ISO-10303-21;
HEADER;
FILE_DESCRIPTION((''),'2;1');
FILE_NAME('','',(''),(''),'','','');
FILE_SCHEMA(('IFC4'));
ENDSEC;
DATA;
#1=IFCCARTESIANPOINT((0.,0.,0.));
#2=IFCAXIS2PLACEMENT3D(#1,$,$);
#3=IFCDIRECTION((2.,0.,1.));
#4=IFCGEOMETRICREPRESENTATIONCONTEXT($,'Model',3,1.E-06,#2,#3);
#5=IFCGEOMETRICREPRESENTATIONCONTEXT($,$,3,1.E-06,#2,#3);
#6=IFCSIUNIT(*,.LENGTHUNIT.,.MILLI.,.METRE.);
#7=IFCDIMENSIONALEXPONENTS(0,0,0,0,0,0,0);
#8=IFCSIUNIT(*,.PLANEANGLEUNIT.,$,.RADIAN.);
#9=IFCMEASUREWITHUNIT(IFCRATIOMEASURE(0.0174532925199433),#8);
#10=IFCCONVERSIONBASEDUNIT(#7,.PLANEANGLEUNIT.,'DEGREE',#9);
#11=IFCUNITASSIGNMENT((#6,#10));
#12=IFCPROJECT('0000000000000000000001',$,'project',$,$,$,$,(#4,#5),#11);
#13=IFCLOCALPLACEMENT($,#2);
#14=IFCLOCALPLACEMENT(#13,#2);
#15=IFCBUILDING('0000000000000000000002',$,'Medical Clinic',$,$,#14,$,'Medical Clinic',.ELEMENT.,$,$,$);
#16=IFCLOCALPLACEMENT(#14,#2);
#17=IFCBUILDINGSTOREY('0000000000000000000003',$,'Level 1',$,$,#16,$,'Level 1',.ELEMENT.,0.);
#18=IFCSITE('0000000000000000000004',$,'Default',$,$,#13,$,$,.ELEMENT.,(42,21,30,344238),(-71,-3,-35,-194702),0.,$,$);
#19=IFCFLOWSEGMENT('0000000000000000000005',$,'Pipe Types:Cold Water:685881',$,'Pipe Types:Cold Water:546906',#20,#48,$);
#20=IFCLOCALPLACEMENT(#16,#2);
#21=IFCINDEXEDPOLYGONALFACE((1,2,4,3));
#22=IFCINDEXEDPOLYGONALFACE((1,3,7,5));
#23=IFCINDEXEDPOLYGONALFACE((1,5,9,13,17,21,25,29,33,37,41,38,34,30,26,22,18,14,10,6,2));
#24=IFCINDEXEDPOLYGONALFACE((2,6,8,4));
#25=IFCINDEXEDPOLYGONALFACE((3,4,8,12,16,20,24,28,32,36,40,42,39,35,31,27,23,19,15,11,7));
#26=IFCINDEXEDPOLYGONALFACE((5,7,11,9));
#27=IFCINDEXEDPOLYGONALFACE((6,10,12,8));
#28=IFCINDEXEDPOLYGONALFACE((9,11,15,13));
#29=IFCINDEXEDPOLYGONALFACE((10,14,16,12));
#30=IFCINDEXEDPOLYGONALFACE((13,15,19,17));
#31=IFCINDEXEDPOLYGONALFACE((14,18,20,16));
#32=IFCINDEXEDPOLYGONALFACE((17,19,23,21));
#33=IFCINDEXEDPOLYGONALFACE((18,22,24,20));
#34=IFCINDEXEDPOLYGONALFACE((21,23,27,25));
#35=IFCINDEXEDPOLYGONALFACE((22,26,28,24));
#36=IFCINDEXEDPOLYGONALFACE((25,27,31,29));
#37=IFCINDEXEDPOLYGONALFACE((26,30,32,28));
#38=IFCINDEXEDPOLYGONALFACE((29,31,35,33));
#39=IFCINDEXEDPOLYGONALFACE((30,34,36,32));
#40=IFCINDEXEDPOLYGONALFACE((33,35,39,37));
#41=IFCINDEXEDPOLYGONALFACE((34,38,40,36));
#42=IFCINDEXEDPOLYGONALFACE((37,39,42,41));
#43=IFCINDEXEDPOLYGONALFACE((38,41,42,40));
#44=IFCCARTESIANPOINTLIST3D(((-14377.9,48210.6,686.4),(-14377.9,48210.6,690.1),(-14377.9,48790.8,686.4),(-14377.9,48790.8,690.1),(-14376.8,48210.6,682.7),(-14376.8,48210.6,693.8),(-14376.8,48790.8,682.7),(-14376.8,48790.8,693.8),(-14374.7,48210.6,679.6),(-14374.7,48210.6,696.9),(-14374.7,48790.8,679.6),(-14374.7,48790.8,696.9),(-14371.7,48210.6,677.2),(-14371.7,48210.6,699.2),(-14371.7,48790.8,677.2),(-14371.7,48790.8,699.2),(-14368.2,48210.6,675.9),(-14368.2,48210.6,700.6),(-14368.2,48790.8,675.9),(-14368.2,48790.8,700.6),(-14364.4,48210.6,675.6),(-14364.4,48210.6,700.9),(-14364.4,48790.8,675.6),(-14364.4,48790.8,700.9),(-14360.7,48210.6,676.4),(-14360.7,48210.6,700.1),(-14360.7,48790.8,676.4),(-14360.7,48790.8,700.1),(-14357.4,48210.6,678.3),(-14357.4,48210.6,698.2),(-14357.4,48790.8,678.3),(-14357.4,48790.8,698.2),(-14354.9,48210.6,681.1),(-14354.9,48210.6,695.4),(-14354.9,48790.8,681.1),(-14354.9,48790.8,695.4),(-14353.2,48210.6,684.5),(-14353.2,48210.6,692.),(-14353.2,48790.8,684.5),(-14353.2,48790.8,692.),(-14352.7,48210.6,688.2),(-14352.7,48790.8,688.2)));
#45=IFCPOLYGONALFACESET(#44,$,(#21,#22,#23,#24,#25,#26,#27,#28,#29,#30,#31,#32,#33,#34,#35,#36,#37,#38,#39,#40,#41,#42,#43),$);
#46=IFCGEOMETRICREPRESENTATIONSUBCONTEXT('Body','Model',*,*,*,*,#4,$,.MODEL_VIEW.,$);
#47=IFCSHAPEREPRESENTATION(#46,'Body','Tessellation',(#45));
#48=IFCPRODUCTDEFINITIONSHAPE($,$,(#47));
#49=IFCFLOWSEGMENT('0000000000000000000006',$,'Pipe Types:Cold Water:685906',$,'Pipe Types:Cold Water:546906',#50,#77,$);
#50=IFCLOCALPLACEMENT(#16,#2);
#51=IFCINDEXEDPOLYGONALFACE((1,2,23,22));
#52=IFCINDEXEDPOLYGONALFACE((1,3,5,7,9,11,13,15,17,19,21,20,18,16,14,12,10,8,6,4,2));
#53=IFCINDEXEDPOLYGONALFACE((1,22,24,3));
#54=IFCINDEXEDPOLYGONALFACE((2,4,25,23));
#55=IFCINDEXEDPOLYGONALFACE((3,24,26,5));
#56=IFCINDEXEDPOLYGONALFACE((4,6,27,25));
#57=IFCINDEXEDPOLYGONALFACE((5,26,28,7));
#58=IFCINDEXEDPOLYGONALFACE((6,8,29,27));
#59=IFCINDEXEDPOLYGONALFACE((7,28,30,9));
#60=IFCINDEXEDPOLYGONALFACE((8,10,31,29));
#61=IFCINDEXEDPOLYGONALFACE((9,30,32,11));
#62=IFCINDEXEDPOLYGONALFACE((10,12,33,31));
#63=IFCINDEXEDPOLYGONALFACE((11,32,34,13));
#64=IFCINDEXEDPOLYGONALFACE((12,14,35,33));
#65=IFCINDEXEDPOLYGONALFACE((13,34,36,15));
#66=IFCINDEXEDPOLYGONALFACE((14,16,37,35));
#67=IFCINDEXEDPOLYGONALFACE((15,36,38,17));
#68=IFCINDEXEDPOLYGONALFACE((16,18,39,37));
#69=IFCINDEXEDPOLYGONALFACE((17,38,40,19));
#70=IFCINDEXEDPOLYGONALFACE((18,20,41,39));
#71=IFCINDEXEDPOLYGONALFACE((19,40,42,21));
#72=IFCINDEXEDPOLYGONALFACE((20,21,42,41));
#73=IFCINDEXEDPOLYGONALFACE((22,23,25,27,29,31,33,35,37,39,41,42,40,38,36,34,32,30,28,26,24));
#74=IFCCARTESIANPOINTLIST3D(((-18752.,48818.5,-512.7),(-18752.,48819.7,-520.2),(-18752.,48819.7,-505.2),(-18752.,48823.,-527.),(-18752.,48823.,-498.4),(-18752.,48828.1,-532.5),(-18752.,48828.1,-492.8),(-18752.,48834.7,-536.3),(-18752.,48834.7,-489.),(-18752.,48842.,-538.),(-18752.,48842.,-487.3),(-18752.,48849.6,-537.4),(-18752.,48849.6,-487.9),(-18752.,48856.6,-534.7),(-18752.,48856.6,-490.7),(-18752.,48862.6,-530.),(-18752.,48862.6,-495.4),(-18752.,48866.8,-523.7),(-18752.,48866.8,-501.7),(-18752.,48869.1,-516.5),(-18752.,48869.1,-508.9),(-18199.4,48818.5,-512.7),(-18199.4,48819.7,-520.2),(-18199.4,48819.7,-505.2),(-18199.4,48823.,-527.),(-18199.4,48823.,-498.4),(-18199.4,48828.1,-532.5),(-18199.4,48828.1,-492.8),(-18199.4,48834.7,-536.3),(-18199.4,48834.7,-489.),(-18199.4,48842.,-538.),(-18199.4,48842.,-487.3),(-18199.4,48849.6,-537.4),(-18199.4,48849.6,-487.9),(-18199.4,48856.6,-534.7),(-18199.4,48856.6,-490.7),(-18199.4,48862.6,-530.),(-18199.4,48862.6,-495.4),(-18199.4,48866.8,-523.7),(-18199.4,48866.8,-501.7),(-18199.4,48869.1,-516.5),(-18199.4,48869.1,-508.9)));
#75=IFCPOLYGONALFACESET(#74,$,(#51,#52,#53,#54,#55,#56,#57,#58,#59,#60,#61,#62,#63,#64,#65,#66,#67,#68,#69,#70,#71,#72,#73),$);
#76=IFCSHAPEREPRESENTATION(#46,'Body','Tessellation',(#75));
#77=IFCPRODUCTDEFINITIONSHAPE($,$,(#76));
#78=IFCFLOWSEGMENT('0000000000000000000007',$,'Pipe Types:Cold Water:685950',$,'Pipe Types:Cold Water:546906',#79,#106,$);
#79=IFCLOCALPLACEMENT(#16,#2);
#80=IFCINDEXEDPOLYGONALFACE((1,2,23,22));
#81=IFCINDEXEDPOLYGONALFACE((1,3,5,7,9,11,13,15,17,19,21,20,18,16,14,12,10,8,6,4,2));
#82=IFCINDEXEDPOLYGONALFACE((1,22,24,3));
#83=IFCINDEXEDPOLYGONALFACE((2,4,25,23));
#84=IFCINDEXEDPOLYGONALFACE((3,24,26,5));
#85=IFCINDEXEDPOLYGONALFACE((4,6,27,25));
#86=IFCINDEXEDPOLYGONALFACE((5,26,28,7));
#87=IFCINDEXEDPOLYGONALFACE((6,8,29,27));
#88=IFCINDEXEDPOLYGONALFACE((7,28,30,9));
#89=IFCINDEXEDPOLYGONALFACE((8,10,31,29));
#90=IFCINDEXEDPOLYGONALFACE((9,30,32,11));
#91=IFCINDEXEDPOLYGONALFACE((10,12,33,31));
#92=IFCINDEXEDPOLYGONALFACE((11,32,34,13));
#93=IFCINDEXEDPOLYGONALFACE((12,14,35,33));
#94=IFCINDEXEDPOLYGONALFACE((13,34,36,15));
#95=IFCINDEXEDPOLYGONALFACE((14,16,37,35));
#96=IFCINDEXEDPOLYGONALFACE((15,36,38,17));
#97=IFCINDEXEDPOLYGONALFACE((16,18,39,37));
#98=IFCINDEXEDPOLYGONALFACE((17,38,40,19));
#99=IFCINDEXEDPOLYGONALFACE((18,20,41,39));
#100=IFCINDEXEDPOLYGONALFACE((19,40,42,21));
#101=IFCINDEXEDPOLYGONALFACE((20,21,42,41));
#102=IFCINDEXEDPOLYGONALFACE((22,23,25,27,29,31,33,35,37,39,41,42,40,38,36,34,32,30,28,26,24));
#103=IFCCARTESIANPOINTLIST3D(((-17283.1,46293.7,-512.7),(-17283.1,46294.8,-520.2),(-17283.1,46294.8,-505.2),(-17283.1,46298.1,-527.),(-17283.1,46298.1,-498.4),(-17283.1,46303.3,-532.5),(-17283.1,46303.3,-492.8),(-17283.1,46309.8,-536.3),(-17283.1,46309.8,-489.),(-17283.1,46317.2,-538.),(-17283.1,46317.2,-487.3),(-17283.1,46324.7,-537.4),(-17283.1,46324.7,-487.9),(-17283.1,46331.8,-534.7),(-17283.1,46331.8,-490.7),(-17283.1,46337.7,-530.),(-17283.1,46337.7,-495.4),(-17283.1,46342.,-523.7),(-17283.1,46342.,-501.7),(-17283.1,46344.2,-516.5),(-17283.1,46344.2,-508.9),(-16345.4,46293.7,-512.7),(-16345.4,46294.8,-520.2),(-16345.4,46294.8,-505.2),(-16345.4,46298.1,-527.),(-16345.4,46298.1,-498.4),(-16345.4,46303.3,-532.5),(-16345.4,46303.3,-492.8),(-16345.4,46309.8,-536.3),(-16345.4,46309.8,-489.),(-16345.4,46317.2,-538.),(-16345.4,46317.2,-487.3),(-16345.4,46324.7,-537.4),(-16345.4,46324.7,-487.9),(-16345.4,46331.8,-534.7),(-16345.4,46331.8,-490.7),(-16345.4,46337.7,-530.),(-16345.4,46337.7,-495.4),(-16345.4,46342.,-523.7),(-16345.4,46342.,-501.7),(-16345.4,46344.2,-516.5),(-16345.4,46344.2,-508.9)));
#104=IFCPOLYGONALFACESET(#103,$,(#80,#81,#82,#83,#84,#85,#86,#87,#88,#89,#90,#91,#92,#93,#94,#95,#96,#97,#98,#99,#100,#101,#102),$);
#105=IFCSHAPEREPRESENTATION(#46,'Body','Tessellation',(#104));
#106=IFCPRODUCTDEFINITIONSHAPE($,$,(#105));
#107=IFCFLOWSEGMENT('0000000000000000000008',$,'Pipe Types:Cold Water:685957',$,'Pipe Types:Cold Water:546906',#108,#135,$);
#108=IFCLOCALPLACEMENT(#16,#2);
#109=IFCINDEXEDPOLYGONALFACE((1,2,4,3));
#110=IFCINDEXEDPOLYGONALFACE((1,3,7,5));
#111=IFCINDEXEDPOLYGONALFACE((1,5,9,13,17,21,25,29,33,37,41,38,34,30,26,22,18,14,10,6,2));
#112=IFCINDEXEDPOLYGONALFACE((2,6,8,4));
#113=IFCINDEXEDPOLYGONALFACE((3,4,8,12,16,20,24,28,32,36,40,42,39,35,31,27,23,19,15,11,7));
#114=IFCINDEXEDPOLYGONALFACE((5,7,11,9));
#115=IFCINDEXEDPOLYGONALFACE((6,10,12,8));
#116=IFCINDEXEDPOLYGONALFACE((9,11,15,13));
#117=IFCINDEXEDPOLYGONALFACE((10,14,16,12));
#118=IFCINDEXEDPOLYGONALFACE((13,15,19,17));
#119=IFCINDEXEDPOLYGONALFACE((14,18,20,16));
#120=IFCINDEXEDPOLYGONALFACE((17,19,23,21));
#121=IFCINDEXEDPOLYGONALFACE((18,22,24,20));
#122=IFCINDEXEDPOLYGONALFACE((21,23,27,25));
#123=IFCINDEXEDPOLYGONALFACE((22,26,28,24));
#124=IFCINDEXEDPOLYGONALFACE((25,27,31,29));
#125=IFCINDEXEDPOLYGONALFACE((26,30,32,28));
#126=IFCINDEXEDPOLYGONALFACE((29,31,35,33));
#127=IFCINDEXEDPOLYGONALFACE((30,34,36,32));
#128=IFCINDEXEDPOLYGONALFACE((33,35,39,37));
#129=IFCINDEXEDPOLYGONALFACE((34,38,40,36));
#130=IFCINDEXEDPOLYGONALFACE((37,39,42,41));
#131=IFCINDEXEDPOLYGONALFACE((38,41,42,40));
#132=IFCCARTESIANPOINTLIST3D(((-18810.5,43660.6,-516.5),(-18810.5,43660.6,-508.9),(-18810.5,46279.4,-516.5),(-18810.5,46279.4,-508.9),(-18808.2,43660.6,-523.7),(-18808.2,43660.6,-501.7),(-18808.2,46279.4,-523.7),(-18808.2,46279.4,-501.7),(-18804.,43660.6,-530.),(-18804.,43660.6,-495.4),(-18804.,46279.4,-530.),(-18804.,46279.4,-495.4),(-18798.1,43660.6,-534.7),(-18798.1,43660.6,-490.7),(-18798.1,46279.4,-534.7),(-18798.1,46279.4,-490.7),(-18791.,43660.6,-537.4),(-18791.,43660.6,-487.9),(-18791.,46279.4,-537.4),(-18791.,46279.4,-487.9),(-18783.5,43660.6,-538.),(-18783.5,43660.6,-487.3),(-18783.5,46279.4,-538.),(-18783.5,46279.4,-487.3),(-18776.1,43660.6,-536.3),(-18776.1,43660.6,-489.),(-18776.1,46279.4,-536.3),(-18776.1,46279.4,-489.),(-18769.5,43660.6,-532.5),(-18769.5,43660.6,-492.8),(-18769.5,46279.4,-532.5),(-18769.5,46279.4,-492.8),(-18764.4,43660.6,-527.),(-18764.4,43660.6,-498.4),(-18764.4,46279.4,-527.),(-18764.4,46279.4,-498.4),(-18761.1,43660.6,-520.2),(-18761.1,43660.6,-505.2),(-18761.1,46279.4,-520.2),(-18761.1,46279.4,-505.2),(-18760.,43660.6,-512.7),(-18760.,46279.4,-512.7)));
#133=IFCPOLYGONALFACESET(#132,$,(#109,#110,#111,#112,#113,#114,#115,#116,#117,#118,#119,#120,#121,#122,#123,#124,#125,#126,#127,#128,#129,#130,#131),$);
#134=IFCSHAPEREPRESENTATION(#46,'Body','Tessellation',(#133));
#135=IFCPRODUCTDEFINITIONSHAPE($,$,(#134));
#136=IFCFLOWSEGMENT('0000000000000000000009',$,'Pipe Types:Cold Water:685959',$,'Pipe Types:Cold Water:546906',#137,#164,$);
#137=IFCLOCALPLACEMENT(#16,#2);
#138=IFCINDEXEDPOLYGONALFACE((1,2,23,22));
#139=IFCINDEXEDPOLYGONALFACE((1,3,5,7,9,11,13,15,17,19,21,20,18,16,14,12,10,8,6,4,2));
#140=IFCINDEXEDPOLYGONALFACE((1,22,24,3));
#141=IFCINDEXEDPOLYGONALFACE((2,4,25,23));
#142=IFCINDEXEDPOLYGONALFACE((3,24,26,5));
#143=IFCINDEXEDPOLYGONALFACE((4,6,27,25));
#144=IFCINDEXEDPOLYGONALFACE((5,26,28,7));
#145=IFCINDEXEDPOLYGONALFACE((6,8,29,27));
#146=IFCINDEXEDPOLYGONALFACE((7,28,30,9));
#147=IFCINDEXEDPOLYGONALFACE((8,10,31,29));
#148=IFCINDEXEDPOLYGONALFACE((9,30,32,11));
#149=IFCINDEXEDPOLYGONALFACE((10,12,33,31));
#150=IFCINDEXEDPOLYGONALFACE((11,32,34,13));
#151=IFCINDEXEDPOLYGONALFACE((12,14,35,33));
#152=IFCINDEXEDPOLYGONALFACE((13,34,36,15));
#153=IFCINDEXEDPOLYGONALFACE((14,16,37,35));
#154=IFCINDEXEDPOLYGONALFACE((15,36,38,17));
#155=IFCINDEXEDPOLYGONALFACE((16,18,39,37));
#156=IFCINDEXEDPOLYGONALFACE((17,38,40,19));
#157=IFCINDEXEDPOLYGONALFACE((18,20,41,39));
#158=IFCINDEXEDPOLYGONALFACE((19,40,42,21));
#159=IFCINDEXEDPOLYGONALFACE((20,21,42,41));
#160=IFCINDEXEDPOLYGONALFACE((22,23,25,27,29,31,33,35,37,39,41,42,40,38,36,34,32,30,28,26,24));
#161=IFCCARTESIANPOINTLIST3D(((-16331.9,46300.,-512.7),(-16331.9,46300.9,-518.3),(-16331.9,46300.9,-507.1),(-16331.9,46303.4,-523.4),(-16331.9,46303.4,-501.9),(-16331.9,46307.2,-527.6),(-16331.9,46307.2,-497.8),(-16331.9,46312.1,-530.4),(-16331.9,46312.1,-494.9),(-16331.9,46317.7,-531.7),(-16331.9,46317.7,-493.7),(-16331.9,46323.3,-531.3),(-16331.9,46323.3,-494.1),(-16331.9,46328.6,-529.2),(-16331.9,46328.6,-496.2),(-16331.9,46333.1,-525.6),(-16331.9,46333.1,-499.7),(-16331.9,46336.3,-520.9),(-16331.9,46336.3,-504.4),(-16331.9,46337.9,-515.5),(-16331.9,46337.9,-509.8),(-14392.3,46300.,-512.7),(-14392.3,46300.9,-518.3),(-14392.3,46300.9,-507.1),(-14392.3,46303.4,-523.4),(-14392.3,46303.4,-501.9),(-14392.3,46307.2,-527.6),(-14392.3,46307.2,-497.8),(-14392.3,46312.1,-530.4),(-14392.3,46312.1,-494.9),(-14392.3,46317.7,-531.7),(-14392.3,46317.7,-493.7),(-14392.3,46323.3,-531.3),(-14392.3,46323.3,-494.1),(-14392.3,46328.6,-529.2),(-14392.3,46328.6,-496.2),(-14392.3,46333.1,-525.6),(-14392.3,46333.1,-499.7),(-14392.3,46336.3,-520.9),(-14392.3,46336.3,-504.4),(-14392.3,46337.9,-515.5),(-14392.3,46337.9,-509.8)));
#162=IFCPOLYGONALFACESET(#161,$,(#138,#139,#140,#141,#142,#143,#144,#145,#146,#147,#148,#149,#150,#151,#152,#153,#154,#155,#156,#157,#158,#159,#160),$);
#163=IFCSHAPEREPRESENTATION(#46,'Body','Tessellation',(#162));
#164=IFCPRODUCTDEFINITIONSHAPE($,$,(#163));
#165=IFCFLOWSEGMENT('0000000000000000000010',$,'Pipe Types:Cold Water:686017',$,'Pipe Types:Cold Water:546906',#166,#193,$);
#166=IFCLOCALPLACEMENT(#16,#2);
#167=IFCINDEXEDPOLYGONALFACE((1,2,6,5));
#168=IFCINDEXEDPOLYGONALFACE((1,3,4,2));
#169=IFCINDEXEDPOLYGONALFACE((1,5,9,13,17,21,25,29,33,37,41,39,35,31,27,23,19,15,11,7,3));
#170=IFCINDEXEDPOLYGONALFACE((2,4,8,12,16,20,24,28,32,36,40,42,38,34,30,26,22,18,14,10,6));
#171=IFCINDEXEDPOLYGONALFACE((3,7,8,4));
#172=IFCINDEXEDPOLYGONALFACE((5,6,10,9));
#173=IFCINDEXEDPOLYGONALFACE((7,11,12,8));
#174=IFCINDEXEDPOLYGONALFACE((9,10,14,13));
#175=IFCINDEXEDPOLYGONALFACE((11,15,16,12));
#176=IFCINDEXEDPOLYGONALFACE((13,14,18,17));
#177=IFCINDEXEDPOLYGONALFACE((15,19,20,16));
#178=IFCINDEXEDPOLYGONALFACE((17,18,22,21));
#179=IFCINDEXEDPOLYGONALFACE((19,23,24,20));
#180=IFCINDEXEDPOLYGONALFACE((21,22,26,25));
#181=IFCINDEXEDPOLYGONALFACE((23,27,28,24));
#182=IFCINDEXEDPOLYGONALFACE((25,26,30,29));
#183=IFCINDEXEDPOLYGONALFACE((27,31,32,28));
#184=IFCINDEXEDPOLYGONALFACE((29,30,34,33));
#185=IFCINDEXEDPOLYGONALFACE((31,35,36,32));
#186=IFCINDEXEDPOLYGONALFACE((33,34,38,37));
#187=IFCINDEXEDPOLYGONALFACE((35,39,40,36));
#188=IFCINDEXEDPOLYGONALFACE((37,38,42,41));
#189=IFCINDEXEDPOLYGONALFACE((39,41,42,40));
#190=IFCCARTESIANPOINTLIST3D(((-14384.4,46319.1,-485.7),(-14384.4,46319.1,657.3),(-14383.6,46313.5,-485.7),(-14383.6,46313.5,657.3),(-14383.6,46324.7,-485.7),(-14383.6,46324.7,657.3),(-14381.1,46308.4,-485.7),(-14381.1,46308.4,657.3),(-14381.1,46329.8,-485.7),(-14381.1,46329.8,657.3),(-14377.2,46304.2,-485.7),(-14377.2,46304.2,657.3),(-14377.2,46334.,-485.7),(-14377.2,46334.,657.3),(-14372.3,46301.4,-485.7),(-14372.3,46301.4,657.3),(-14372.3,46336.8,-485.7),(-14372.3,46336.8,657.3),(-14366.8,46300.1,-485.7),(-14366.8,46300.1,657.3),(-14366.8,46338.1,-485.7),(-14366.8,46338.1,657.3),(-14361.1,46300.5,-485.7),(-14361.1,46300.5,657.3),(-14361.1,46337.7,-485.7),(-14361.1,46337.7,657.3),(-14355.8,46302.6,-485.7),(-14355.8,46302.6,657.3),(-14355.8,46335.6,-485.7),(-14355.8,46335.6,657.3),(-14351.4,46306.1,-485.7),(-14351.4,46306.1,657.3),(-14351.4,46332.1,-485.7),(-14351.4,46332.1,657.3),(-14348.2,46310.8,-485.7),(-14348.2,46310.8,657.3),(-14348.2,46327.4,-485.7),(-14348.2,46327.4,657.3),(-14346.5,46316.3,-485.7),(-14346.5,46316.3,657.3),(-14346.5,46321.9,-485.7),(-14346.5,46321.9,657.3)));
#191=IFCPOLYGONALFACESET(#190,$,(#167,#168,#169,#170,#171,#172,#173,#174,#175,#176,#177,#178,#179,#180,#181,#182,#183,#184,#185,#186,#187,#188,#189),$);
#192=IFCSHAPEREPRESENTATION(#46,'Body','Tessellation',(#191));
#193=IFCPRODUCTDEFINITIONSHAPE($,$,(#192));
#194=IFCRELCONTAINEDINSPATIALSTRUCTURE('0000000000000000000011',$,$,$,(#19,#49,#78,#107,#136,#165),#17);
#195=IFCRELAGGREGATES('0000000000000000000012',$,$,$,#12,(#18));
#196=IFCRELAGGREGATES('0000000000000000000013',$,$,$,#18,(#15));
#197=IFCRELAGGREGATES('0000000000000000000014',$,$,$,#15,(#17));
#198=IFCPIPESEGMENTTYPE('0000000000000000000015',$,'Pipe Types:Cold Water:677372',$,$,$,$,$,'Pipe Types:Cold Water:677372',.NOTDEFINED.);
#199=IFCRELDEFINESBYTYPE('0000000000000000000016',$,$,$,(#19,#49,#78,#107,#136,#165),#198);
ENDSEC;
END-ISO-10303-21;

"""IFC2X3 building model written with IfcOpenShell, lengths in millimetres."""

from ifc_helpers import new_model, entity, si_unit, converted_unit, direction, frame, frame_2d, origin, origin_2d_with_axis, place, context, subcontext, project, spatial, circle, extrude, type_object, element, save


model = new_model("IFC2X3")

# Units and contexts
model_context = context("Model", 3, precision=1e-06, world=origin(), true_north=direction((2.0, 0.0, 1.0)))
context_of_model = context(None, 3, precision=1e-06, world=origin(), true_north=direction((2.0, 0.0, 1.0)))
body_context = subcontext(model_context, "Body", "Model", "MODEL_VIEW")
ifc_project = project(units=[si_unit("LENGTHUNIT", "METRE", prefix="MILLI"), converted_unit("PLANEANGLEUNIT", "DEGREE", entity("IfcRatioMeasure", 0.0174532925199433), si_unit("PLANEANGLEUNIT", "RADIAN"), dimensions=[0, 0, 0, 0, 0, 0, 0])], contexts=[model_context, context_of_model])

# Site, building, storey
site_placement = place(None, origin())
site = spatial("IfcSite", under=ifc_project, at=site_placement, Name="Default", CompositionType="ELEMENT", RefLatitude=(42, 21, 30, 344238), RefLongitude=(-71, -3, -35, -194702), RefElevation=0.0)
building_placement = place(site_placement, origin())
building = spatial("IfcBuilding", under=site, at=building_placement, Name="Medical Clinic", LongName="Medical Clinic", CompositionType="ELEMENT")
storey_placement = place(building_placement, origin())
storey = spatial("IfcBuildingStorey", under=building, at=storey_placement, Name="Level 1", LongName="Level 1", CompositionType="ELEMENT", Elevation=0.0)

# Flow segments
pipe_segment_type = type_object("IfcPipeSegmentType", Name="Pipe Types:Cold Water:677372", ElementType="Pipe Types:Cold Water:677372", PredefinedType="NOTDEFINED")
flow_segment_1_placement = place(storey_placement, origin())
element("IfcFlowSegment", 1, at=flow_segment_1_placement, inside=storey, type_object=pipe_segment_type, Name="Pipe Types:Cold Water:685881", ObjectType="Pipe Types:Cold Water:546906", context=body_context, shape_type="SweptSolid", body=[
    extrude(circle(Radius=12.7, at=origin_2d_with_axis()), frame((-14365.4, 48210.6, 688.2), z_axis=(0.0, 1.0, 0.0), x_axis=(1.0, 0.0, 0.0)), (0.0, 0.0, 1.0), 580.1),
])
flow_segment_2_placement = place(storey_placement, origin())
element("IfcFlowSegment", 2, at=flow_segment_2_placement, inside=storey, type_object=pipe_segment_type, Name="Pipe Types:Cold Water:685906", ObjectType="Pipe Types:Cold Water:546906", context=body_context, shape_type="SweptSolid", body=[
    extrude(circle(Radius=25.4, at=frame_2d((0.0, 0.0), x_axis=(1.0, 0.0))), frame((-18752.0, 48843.9, -512.7), z_axis=(1.0, 0.0, 0.0), x_axis=(0.0, -1.0, 0.0)), (0.0, 0.0, 1.0), 552.6),
])
flow_segment_3_placement = place(storey_placement, origin())
element("IfcFlowSegment", 3, at=flow_segment_3_placement, inside=storey, type_object=pipe_segment_type, Name="Pipe Types:Cold Water:685950", ObjectType="Pipe Types:Cold Water:546906", context=body_context, shape_type="SweptSolid", body=[
    extrude(circle(Radius=25.4, at=frame_2d((0.0, 0.0), x_axis=(1.0, 0.0))), frame((-17283.1, 46319.1, -512.7), z_axis=(1.0, 0.0, 0.0), x_axis=(0.0, -1.0, 0.0)), (0.0, 0.0, 1.0), 937.8),
])
flow_segment_4_placement = place(storey_placement, origin())
element("IfcFlowSegment", 4, at=flow_segment_4_placement, inside=storey, type_object=pipe_segment_type, Name="Pipe Types:Cold Water:685957", ObjectType="Pipe Types:Cold Water:546906", context=body_context, shape_type="SweptSolid", body=[
    extrude(circle(Radius=25.4, at=frame_2d((0.0, 0.0), x_axis=(1.0, 0.0))), frame((-18785.4, 43660.6, -512.7), z_axis=(0.0, 1.0, 0.0), x_axis=(1.0, 0.0, 0.0)), (0.0, 0.0, 1.0), 2618.8),
])
flow_segment_5_placement = place(storey_placement, origin())
element("IfcFlowSegment", 5, at=flow_segment_5_placement, inside=storey, type_object=pipe_segment_type, Name="Pipe Types:Cold Water:685959", ObjectType="Pipe Types:Cold Water:546906", context=body_context, shape_type="SweptSolid", body=[
    extrude(circle(Radius=19.1, at=origin_2d_with_axis()), frame((-16331.9, 46319.1, -512.7), z_axis=(1.0, 0.0, 0.0), x_axis=(0.0, -1.0, 0.0)), (0.0, 0.0, 1.0), 1939.5),
])
flow_segment_6_placement = place(storey_placement, origin())
element("IfcFlowSegment", 6, at=flow_segment_6_placement, inside=storey, type_object=pipe_segment_type, Name="Pipe Types:Cold Water:686017", ObjectType="Pipe Types:Cold Water:546906", context=body_context, shape_type="SweptSolid", body=[
    extrude(circle(Radius=19.1, at=origin_2d_with_axis()), frame((-14365.4, 46319.1, -485.7), z_axis=(0.0, 0.0, 1.0), x_axis=(-1.0, 0.0, 0.0)), (0.0, 0.0, 1.0), 1143.0),
])

save(model, "model.ifc")
